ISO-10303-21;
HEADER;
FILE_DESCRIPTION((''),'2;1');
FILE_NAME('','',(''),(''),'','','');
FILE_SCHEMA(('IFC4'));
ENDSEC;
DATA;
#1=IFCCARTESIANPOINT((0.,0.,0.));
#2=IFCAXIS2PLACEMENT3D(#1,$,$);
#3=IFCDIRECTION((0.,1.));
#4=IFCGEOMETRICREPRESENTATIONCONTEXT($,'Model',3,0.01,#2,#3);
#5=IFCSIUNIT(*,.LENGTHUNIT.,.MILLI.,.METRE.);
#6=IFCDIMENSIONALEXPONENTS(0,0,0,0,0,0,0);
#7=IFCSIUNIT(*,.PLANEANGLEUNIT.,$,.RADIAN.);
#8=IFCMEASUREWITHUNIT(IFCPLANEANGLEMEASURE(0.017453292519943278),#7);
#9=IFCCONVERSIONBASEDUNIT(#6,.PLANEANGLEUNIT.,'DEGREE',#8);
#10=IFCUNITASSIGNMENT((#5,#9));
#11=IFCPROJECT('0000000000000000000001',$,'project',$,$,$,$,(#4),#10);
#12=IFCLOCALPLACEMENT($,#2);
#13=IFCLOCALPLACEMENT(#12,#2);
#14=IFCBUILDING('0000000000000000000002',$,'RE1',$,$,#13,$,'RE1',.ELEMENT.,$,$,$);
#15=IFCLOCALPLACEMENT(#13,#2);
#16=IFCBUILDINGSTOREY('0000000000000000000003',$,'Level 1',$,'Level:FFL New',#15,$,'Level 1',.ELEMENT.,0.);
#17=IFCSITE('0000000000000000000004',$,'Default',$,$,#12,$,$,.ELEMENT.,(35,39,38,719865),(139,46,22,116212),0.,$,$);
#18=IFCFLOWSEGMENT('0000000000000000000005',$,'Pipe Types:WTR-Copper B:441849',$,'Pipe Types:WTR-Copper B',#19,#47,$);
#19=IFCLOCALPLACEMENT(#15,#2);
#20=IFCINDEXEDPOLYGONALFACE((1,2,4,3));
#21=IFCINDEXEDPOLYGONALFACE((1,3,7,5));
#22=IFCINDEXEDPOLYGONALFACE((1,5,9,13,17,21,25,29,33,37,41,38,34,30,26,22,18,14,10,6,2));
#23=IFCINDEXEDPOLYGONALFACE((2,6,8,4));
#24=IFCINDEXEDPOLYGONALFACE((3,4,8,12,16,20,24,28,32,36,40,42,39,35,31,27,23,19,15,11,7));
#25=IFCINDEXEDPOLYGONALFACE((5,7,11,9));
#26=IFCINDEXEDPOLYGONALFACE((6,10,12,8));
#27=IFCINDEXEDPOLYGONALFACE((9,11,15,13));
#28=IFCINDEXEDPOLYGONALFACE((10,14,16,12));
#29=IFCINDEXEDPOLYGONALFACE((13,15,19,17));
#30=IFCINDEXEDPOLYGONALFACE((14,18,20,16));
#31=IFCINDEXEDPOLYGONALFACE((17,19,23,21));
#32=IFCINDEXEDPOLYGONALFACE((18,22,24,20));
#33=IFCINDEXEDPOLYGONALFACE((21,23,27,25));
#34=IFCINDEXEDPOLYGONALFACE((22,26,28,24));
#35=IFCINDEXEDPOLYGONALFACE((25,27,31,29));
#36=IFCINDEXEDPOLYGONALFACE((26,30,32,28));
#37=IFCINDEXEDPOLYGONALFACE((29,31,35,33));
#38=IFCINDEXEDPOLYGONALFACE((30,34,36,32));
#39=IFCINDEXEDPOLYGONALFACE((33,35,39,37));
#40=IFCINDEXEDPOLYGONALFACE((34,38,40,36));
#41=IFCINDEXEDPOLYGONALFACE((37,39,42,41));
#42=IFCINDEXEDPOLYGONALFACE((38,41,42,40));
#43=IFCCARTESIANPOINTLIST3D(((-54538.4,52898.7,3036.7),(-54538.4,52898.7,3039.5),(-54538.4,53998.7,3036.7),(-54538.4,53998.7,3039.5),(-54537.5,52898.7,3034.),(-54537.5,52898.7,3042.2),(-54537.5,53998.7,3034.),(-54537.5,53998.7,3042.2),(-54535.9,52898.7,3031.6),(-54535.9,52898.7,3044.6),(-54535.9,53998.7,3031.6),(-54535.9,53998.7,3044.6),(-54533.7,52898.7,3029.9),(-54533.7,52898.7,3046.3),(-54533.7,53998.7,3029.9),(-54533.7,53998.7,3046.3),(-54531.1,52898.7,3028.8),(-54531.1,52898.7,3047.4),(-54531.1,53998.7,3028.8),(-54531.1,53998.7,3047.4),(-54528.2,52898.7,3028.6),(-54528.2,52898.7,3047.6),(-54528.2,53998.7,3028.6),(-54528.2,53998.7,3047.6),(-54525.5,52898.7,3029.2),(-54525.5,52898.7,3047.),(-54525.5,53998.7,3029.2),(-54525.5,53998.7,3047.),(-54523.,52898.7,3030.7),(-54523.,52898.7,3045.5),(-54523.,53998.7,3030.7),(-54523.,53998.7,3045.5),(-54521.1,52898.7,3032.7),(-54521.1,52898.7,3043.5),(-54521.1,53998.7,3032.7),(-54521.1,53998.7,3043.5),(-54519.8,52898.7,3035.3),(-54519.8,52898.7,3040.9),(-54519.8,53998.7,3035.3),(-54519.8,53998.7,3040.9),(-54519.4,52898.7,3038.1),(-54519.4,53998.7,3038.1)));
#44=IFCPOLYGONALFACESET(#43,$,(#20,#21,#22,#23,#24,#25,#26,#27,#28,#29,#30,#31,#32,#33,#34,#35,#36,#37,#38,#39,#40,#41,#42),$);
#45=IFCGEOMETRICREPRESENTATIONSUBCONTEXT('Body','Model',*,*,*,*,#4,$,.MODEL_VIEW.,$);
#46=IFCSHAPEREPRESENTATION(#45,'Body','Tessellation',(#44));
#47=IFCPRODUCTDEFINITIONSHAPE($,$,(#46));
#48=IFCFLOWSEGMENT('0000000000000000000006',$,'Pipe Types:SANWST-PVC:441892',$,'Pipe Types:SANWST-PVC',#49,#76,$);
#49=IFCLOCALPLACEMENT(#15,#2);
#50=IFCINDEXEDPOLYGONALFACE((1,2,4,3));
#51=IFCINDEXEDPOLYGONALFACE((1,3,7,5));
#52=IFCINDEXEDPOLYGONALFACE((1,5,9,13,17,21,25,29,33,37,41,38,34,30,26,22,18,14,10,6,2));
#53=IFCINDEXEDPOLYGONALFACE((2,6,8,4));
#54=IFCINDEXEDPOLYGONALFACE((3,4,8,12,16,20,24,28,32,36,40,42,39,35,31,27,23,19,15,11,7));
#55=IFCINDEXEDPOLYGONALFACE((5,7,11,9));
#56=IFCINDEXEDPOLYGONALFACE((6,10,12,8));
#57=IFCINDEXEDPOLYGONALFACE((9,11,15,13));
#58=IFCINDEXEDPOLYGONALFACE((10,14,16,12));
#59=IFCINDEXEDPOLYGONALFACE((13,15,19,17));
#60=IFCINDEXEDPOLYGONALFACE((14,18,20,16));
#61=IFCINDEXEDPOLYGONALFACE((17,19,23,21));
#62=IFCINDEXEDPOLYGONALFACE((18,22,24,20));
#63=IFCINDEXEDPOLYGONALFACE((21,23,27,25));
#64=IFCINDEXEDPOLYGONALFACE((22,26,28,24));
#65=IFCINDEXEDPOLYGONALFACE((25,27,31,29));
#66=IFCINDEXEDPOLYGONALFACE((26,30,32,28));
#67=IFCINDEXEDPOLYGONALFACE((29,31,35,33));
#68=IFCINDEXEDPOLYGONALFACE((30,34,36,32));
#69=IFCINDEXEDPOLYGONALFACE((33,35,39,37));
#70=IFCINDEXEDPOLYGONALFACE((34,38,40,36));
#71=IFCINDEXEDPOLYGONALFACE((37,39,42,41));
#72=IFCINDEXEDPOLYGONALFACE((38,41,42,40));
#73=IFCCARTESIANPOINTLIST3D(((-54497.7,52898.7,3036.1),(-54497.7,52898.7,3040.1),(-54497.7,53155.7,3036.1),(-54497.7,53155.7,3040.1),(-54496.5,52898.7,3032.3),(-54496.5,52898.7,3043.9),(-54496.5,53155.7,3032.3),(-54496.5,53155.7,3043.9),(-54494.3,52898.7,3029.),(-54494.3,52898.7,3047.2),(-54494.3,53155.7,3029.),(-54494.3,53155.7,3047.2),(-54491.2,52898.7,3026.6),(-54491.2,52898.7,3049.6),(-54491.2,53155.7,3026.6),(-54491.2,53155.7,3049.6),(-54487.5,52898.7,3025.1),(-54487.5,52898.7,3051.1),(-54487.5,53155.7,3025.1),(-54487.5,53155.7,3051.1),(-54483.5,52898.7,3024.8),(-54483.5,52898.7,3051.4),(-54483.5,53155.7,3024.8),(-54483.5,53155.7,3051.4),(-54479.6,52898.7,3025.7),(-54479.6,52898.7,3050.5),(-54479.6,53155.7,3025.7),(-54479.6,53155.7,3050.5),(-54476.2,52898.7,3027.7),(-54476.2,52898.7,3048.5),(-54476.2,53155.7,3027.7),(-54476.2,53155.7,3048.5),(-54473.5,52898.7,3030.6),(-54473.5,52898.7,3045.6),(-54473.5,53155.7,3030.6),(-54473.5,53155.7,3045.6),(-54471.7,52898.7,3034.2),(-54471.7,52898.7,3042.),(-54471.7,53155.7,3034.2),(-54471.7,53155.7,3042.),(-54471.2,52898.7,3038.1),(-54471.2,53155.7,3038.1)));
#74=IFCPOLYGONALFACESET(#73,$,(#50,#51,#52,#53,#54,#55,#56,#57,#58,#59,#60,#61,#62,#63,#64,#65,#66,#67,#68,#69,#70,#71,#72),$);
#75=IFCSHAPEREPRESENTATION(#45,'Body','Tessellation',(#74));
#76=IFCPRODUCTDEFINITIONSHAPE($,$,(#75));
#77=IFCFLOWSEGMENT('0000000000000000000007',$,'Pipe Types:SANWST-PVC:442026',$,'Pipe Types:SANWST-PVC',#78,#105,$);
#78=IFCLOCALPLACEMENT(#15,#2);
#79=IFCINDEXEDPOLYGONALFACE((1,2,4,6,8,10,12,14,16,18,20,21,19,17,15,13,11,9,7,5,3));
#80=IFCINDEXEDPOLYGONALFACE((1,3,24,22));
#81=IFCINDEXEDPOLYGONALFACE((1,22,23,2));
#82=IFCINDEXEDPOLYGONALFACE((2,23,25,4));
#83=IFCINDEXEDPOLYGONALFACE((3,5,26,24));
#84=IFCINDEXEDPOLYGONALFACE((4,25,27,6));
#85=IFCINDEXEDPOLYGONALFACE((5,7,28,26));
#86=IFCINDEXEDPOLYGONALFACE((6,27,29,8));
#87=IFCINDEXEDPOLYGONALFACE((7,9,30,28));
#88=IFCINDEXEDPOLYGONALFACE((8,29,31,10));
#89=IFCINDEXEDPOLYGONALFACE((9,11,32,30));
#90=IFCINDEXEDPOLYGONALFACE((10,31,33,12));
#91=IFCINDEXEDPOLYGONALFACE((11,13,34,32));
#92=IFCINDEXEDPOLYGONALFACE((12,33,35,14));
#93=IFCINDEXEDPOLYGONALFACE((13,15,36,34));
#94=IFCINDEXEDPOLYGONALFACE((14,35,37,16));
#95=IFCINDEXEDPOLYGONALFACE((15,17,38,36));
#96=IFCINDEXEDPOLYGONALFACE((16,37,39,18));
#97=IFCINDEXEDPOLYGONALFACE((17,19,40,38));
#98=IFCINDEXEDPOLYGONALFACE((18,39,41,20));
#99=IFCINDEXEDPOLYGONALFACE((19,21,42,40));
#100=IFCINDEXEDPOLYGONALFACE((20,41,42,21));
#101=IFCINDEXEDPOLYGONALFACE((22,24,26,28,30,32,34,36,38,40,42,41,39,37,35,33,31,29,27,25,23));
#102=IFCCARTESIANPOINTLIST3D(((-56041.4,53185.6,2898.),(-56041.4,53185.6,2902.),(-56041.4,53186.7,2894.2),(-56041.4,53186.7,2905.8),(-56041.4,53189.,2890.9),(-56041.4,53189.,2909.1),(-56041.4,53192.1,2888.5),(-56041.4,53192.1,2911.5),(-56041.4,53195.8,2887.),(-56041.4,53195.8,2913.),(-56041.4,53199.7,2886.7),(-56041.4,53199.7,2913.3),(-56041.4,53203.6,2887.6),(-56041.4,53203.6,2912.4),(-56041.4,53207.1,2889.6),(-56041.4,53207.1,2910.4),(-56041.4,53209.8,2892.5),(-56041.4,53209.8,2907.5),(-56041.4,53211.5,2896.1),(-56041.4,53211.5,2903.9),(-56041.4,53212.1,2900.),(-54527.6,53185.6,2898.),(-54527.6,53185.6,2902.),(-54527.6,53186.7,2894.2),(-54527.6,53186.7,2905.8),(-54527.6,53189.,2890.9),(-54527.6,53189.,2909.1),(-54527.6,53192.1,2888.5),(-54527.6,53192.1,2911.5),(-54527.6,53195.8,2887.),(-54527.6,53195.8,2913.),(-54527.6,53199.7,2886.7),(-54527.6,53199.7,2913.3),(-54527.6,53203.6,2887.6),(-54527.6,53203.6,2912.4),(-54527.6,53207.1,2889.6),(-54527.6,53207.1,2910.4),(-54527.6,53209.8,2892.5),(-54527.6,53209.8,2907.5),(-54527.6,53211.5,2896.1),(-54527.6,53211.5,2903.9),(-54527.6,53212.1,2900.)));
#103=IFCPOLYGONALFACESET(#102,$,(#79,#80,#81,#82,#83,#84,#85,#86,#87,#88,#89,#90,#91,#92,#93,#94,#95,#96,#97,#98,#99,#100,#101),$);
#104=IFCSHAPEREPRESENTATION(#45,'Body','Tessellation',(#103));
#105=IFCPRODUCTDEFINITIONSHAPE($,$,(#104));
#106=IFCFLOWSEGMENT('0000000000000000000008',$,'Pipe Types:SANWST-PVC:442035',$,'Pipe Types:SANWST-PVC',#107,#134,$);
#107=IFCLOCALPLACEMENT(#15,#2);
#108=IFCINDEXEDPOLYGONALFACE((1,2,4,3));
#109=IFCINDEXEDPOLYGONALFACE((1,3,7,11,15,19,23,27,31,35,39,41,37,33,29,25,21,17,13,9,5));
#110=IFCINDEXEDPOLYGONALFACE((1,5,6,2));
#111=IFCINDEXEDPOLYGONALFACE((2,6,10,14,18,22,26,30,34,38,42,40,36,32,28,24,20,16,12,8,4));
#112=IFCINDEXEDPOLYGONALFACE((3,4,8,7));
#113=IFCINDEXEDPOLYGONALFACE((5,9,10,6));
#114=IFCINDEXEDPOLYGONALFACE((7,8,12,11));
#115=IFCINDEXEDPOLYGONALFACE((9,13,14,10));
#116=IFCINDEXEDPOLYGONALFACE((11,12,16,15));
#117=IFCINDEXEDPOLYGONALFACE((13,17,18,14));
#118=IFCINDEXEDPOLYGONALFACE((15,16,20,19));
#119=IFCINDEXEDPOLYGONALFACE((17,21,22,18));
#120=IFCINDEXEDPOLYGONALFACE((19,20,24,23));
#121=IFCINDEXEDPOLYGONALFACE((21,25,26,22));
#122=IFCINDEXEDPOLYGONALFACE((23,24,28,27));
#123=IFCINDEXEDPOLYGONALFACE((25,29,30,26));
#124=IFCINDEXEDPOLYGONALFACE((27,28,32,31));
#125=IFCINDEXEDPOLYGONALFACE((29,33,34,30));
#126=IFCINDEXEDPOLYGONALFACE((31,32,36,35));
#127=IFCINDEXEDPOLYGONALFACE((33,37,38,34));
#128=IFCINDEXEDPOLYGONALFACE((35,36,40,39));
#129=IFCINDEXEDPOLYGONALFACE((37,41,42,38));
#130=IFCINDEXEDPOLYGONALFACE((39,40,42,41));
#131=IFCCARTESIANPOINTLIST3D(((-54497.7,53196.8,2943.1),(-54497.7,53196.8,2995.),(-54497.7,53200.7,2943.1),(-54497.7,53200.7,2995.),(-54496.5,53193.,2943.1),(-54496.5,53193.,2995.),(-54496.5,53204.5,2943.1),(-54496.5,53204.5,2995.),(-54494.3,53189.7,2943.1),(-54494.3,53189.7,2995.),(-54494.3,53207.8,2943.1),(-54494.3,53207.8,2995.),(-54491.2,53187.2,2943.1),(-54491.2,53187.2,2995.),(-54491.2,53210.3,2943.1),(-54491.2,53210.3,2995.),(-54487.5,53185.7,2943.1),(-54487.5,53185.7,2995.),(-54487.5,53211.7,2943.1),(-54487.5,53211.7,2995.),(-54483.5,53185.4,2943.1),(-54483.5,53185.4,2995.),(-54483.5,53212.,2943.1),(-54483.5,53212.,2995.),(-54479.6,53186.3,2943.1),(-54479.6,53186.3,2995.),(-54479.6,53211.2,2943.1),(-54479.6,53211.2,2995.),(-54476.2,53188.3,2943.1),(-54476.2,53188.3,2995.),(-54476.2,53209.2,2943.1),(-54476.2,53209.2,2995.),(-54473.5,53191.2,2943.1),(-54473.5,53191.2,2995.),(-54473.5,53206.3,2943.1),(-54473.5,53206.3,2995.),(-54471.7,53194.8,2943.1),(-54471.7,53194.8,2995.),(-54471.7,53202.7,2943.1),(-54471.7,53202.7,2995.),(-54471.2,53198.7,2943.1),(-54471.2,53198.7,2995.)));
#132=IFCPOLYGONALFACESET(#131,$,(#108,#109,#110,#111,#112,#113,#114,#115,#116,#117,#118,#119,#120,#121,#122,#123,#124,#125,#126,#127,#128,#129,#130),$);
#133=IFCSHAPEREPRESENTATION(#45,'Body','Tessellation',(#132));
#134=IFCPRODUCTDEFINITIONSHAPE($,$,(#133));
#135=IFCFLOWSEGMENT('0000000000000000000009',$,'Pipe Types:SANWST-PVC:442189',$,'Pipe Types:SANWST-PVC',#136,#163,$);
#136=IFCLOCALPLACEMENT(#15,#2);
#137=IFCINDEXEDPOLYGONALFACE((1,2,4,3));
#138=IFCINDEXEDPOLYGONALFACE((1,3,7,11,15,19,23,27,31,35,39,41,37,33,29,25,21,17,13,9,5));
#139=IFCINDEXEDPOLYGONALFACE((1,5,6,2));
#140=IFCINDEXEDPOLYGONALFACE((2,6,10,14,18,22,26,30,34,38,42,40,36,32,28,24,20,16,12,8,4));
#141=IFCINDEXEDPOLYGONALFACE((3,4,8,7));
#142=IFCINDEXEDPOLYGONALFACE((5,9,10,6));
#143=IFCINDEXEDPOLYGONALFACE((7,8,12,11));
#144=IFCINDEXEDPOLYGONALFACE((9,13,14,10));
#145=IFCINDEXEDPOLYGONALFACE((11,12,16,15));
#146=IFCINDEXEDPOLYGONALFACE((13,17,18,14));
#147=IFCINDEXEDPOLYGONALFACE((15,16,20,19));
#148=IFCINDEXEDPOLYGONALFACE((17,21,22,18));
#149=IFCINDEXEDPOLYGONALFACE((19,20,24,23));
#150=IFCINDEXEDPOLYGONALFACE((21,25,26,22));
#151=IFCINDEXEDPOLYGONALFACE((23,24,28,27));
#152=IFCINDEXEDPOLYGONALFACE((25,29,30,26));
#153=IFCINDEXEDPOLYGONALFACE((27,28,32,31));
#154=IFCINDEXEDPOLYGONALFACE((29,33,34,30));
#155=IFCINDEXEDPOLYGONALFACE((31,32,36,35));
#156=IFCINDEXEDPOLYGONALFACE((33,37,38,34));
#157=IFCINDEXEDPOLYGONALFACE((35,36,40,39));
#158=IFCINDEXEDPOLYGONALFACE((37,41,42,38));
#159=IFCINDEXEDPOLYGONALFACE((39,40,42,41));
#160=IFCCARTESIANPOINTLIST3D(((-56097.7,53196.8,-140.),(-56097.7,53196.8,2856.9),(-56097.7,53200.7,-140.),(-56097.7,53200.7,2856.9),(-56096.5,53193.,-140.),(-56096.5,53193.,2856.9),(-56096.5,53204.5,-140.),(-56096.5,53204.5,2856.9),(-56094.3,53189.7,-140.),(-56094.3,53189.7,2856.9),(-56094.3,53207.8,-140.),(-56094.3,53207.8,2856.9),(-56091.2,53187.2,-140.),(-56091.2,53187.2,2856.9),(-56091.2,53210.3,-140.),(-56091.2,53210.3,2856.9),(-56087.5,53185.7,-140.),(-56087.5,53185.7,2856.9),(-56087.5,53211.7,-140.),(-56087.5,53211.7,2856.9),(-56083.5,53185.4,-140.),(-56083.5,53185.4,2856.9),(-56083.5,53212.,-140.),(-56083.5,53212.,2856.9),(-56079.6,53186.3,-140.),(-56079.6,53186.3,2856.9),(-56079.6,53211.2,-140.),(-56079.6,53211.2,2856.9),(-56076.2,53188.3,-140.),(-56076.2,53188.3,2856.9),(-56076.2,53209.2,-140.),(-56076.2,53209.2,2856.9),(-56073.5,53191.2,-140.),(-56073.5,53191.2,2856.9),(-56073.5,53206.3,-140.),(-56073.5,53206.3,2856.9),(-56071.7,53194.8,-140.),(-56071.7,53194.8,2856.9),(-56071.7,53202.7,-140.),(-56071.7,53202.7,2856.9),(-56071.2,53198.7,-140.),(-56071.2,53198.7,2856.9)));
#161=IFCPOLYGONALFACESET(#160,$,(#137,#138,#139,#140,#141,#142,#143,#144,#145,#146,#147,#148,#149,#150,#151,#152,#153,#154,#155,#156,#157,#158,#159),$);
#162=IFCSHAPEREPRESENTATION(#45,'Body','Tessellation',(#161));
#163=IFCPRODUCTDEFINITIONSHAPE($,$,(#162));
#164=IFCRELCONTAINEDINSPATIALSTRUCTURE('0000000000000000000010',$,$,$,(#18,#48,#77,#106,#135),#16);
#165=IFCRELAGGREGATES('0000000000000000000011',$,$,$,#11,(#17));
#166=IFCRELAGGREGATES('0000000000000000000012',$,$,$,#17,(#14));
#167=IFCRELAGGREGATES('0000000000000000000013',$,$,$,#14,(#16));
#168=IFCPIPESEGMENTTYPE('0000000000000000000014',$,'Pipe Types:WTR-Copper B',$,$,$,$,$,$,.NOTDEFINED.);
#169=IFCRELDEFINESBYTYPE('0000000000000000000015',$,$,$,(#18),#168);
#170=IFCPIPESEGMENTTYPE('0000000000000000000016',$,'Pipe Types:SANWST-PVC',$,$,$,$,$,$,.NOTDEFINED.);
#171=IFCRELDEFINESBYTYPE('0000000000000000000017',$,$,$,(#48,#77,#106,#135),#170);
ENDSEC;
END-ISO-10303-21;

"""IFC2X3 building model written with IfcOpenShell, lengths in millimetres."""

from ifc_helpers import new_model, entity, si_unit, converted_unit, direction, frame, origin, origin_2d_with_axis, place, context, subcontext, project, spatial, circle, extrude, type_object, element, save


model = new_model("IFC2X3")

# Units and contexts
model_context = context("Model", 3, precision=0.01, world=origin(), true_north=direction((0.0, 1.0)))
body_context = subcontext(model_context, "Body", "Model", "MODEL_VIEW")
ifc_project = project(units=[si_unit("LENGTHUNIT", "METRE", prefix="MILLI"), converted_unit("PLANEANGLEUNIT", "DEGREE", entity("IfcPlaneAngleMeasure", 0.017453292519943278), si_unit("PLANEANGLEUNIT", "RADIAN"), dimensions=[0, 0, 0, 0, 0, 0, 0])], contexts=[model_context])

# Site, building, storey
site_placement = place(None, origin())
site = spatial("IfcSite", under=ifc_project, at=site_placement, Name="Default", CompositionType="ELEMENT", RefLatitude=(35, 39, 38, 719865), RefLongitude=(139, 46, 22, 116212), RefElevation=0.0)
building_placement = place(site_placement, origin())
building = spatial("IfcBuilding", under=site, at=building_placement, Name="RE1", LongName="RE1", CompositionType="ELEMENT")
storey_placement = place(building_placement, origin())
storey = spatial("IfcBuildingStorey", under=building, at=storey_placement, Name="Level 1", ObjectType="Level:FFL New", LongName="Level 1", CompositionType="ELEMENT", Elevation=0.0)

# Flow segments
pipe_segment_type_1 = type_object("IfcPipeSegmentType", Name="Pipe Types:WTR-Copper B", PredefinedType="NOTDEFINED")
flow_segment_1_placement = place(storey_placement, origin())
element("IfcFlowSegment", 1, at=flow_segment_1_placement, inside=storey, type_object=pipe_segment_type_1, Name="Pipe Types:WTR-Copper B:441849", ObjectType="Pipe Types:WTR-Copper B", context=body_context, shape_type="SweptSolid", body=[
    extrude(circle(Radius=9.5, at=origin_2d_with_axis()), frame((-54528.9, 52898.7, 3038.1), z_axis=(0.0, 1.0, 0.0), x_axis=(1.0, 0.0, 0.0)), (0.0, 0.0, 1.0), 1100.0),
])
pipe_segment_type_2 = type_object("IfcPipeSegmentType", Name="Pipe Types:SANWST-PVC", PredefinedType="NOTDEFINED")
flow_segment_2_placement = place(storey_placement, origin())
element("IfcFlowSegment", 2, at=flow_segment_2_placement, inside=storey, type_object=pipe_segment_type_2, Name="Pipe Types:SANWST-PVC:441892", ObjectType="Pipe Types:SANWST-PVC", context=body_context, shape_type="SweptSolid", body=[
    extrude(circle(Radius=13.3, at=origin_2d_with_axis()), frame((-54484.5, 52898.7, 3038.1), z_axis=(0.0, 1.0, 0.0), x_axis=(1.0, 0.0, 0.0)), (0.0, 0.0, 1.0), 256.9),
])
flow_segment_3_placement = place(storey_placement, origin())
element("IfcFlowSegment", 3, at=flow_segment_3_placement, inside=storey, type_object=pipe_segment_type_2, Name="Pipe Types:SANWST-PVC:442026", ObjectType="Pipe Types:SANWST-PVC", context=body_context, shape_type="SweptSolid", body=[
    extrude(circle(Radius=13.3, at=origin_2d_with_axis()), frame((-56041.4, 53198.7, 2900.0), z_axis=(1.0, 0.0, 0.0), x_axis=(0.0, 1.0, 0.0)), (0.0, 0.0, 1.0), 1513.9),
])
flow_segment_4_placement = place(storey_placement, origin())
element("IfcFlowSegment", 4, at=flow_segment_4_placement, inside=storey, type_object=pipe_segment_type_2, Name="Pipe Types:SANWST-PVC:442035", ObjectType="Pipe Types:SANWST-PVC", context=body_context, shape_type="SweptSolid", body=[
    extrude(circle(Radius=13.3, at=origin_2d_with_axis()), frame((-54484.5, 53198.7, 2943.1)), (0.0, 0.0, 1.0), 52.0),
])
flow_segment_5_placement = place(storey_placement, origin())
element("IfcFlowSegment", 5, at=flow_segment_5_placement, inside=storey, type_object=pipe_segment_type_2, Name="Pipe Types:SANWST-PVC:442189", ObjectType="Pipe Types:SANWST-PVC", context=body_context, shape_type="SweptSolid", body=[
    extrude(circle(Radius=13.3, at=origin_2d_with_axis()), frame((-56084.5, 53198.7, -140.0)), (0.0, 0.0, 1.0), 2996.9),
])

save(model, "model.ifc")
